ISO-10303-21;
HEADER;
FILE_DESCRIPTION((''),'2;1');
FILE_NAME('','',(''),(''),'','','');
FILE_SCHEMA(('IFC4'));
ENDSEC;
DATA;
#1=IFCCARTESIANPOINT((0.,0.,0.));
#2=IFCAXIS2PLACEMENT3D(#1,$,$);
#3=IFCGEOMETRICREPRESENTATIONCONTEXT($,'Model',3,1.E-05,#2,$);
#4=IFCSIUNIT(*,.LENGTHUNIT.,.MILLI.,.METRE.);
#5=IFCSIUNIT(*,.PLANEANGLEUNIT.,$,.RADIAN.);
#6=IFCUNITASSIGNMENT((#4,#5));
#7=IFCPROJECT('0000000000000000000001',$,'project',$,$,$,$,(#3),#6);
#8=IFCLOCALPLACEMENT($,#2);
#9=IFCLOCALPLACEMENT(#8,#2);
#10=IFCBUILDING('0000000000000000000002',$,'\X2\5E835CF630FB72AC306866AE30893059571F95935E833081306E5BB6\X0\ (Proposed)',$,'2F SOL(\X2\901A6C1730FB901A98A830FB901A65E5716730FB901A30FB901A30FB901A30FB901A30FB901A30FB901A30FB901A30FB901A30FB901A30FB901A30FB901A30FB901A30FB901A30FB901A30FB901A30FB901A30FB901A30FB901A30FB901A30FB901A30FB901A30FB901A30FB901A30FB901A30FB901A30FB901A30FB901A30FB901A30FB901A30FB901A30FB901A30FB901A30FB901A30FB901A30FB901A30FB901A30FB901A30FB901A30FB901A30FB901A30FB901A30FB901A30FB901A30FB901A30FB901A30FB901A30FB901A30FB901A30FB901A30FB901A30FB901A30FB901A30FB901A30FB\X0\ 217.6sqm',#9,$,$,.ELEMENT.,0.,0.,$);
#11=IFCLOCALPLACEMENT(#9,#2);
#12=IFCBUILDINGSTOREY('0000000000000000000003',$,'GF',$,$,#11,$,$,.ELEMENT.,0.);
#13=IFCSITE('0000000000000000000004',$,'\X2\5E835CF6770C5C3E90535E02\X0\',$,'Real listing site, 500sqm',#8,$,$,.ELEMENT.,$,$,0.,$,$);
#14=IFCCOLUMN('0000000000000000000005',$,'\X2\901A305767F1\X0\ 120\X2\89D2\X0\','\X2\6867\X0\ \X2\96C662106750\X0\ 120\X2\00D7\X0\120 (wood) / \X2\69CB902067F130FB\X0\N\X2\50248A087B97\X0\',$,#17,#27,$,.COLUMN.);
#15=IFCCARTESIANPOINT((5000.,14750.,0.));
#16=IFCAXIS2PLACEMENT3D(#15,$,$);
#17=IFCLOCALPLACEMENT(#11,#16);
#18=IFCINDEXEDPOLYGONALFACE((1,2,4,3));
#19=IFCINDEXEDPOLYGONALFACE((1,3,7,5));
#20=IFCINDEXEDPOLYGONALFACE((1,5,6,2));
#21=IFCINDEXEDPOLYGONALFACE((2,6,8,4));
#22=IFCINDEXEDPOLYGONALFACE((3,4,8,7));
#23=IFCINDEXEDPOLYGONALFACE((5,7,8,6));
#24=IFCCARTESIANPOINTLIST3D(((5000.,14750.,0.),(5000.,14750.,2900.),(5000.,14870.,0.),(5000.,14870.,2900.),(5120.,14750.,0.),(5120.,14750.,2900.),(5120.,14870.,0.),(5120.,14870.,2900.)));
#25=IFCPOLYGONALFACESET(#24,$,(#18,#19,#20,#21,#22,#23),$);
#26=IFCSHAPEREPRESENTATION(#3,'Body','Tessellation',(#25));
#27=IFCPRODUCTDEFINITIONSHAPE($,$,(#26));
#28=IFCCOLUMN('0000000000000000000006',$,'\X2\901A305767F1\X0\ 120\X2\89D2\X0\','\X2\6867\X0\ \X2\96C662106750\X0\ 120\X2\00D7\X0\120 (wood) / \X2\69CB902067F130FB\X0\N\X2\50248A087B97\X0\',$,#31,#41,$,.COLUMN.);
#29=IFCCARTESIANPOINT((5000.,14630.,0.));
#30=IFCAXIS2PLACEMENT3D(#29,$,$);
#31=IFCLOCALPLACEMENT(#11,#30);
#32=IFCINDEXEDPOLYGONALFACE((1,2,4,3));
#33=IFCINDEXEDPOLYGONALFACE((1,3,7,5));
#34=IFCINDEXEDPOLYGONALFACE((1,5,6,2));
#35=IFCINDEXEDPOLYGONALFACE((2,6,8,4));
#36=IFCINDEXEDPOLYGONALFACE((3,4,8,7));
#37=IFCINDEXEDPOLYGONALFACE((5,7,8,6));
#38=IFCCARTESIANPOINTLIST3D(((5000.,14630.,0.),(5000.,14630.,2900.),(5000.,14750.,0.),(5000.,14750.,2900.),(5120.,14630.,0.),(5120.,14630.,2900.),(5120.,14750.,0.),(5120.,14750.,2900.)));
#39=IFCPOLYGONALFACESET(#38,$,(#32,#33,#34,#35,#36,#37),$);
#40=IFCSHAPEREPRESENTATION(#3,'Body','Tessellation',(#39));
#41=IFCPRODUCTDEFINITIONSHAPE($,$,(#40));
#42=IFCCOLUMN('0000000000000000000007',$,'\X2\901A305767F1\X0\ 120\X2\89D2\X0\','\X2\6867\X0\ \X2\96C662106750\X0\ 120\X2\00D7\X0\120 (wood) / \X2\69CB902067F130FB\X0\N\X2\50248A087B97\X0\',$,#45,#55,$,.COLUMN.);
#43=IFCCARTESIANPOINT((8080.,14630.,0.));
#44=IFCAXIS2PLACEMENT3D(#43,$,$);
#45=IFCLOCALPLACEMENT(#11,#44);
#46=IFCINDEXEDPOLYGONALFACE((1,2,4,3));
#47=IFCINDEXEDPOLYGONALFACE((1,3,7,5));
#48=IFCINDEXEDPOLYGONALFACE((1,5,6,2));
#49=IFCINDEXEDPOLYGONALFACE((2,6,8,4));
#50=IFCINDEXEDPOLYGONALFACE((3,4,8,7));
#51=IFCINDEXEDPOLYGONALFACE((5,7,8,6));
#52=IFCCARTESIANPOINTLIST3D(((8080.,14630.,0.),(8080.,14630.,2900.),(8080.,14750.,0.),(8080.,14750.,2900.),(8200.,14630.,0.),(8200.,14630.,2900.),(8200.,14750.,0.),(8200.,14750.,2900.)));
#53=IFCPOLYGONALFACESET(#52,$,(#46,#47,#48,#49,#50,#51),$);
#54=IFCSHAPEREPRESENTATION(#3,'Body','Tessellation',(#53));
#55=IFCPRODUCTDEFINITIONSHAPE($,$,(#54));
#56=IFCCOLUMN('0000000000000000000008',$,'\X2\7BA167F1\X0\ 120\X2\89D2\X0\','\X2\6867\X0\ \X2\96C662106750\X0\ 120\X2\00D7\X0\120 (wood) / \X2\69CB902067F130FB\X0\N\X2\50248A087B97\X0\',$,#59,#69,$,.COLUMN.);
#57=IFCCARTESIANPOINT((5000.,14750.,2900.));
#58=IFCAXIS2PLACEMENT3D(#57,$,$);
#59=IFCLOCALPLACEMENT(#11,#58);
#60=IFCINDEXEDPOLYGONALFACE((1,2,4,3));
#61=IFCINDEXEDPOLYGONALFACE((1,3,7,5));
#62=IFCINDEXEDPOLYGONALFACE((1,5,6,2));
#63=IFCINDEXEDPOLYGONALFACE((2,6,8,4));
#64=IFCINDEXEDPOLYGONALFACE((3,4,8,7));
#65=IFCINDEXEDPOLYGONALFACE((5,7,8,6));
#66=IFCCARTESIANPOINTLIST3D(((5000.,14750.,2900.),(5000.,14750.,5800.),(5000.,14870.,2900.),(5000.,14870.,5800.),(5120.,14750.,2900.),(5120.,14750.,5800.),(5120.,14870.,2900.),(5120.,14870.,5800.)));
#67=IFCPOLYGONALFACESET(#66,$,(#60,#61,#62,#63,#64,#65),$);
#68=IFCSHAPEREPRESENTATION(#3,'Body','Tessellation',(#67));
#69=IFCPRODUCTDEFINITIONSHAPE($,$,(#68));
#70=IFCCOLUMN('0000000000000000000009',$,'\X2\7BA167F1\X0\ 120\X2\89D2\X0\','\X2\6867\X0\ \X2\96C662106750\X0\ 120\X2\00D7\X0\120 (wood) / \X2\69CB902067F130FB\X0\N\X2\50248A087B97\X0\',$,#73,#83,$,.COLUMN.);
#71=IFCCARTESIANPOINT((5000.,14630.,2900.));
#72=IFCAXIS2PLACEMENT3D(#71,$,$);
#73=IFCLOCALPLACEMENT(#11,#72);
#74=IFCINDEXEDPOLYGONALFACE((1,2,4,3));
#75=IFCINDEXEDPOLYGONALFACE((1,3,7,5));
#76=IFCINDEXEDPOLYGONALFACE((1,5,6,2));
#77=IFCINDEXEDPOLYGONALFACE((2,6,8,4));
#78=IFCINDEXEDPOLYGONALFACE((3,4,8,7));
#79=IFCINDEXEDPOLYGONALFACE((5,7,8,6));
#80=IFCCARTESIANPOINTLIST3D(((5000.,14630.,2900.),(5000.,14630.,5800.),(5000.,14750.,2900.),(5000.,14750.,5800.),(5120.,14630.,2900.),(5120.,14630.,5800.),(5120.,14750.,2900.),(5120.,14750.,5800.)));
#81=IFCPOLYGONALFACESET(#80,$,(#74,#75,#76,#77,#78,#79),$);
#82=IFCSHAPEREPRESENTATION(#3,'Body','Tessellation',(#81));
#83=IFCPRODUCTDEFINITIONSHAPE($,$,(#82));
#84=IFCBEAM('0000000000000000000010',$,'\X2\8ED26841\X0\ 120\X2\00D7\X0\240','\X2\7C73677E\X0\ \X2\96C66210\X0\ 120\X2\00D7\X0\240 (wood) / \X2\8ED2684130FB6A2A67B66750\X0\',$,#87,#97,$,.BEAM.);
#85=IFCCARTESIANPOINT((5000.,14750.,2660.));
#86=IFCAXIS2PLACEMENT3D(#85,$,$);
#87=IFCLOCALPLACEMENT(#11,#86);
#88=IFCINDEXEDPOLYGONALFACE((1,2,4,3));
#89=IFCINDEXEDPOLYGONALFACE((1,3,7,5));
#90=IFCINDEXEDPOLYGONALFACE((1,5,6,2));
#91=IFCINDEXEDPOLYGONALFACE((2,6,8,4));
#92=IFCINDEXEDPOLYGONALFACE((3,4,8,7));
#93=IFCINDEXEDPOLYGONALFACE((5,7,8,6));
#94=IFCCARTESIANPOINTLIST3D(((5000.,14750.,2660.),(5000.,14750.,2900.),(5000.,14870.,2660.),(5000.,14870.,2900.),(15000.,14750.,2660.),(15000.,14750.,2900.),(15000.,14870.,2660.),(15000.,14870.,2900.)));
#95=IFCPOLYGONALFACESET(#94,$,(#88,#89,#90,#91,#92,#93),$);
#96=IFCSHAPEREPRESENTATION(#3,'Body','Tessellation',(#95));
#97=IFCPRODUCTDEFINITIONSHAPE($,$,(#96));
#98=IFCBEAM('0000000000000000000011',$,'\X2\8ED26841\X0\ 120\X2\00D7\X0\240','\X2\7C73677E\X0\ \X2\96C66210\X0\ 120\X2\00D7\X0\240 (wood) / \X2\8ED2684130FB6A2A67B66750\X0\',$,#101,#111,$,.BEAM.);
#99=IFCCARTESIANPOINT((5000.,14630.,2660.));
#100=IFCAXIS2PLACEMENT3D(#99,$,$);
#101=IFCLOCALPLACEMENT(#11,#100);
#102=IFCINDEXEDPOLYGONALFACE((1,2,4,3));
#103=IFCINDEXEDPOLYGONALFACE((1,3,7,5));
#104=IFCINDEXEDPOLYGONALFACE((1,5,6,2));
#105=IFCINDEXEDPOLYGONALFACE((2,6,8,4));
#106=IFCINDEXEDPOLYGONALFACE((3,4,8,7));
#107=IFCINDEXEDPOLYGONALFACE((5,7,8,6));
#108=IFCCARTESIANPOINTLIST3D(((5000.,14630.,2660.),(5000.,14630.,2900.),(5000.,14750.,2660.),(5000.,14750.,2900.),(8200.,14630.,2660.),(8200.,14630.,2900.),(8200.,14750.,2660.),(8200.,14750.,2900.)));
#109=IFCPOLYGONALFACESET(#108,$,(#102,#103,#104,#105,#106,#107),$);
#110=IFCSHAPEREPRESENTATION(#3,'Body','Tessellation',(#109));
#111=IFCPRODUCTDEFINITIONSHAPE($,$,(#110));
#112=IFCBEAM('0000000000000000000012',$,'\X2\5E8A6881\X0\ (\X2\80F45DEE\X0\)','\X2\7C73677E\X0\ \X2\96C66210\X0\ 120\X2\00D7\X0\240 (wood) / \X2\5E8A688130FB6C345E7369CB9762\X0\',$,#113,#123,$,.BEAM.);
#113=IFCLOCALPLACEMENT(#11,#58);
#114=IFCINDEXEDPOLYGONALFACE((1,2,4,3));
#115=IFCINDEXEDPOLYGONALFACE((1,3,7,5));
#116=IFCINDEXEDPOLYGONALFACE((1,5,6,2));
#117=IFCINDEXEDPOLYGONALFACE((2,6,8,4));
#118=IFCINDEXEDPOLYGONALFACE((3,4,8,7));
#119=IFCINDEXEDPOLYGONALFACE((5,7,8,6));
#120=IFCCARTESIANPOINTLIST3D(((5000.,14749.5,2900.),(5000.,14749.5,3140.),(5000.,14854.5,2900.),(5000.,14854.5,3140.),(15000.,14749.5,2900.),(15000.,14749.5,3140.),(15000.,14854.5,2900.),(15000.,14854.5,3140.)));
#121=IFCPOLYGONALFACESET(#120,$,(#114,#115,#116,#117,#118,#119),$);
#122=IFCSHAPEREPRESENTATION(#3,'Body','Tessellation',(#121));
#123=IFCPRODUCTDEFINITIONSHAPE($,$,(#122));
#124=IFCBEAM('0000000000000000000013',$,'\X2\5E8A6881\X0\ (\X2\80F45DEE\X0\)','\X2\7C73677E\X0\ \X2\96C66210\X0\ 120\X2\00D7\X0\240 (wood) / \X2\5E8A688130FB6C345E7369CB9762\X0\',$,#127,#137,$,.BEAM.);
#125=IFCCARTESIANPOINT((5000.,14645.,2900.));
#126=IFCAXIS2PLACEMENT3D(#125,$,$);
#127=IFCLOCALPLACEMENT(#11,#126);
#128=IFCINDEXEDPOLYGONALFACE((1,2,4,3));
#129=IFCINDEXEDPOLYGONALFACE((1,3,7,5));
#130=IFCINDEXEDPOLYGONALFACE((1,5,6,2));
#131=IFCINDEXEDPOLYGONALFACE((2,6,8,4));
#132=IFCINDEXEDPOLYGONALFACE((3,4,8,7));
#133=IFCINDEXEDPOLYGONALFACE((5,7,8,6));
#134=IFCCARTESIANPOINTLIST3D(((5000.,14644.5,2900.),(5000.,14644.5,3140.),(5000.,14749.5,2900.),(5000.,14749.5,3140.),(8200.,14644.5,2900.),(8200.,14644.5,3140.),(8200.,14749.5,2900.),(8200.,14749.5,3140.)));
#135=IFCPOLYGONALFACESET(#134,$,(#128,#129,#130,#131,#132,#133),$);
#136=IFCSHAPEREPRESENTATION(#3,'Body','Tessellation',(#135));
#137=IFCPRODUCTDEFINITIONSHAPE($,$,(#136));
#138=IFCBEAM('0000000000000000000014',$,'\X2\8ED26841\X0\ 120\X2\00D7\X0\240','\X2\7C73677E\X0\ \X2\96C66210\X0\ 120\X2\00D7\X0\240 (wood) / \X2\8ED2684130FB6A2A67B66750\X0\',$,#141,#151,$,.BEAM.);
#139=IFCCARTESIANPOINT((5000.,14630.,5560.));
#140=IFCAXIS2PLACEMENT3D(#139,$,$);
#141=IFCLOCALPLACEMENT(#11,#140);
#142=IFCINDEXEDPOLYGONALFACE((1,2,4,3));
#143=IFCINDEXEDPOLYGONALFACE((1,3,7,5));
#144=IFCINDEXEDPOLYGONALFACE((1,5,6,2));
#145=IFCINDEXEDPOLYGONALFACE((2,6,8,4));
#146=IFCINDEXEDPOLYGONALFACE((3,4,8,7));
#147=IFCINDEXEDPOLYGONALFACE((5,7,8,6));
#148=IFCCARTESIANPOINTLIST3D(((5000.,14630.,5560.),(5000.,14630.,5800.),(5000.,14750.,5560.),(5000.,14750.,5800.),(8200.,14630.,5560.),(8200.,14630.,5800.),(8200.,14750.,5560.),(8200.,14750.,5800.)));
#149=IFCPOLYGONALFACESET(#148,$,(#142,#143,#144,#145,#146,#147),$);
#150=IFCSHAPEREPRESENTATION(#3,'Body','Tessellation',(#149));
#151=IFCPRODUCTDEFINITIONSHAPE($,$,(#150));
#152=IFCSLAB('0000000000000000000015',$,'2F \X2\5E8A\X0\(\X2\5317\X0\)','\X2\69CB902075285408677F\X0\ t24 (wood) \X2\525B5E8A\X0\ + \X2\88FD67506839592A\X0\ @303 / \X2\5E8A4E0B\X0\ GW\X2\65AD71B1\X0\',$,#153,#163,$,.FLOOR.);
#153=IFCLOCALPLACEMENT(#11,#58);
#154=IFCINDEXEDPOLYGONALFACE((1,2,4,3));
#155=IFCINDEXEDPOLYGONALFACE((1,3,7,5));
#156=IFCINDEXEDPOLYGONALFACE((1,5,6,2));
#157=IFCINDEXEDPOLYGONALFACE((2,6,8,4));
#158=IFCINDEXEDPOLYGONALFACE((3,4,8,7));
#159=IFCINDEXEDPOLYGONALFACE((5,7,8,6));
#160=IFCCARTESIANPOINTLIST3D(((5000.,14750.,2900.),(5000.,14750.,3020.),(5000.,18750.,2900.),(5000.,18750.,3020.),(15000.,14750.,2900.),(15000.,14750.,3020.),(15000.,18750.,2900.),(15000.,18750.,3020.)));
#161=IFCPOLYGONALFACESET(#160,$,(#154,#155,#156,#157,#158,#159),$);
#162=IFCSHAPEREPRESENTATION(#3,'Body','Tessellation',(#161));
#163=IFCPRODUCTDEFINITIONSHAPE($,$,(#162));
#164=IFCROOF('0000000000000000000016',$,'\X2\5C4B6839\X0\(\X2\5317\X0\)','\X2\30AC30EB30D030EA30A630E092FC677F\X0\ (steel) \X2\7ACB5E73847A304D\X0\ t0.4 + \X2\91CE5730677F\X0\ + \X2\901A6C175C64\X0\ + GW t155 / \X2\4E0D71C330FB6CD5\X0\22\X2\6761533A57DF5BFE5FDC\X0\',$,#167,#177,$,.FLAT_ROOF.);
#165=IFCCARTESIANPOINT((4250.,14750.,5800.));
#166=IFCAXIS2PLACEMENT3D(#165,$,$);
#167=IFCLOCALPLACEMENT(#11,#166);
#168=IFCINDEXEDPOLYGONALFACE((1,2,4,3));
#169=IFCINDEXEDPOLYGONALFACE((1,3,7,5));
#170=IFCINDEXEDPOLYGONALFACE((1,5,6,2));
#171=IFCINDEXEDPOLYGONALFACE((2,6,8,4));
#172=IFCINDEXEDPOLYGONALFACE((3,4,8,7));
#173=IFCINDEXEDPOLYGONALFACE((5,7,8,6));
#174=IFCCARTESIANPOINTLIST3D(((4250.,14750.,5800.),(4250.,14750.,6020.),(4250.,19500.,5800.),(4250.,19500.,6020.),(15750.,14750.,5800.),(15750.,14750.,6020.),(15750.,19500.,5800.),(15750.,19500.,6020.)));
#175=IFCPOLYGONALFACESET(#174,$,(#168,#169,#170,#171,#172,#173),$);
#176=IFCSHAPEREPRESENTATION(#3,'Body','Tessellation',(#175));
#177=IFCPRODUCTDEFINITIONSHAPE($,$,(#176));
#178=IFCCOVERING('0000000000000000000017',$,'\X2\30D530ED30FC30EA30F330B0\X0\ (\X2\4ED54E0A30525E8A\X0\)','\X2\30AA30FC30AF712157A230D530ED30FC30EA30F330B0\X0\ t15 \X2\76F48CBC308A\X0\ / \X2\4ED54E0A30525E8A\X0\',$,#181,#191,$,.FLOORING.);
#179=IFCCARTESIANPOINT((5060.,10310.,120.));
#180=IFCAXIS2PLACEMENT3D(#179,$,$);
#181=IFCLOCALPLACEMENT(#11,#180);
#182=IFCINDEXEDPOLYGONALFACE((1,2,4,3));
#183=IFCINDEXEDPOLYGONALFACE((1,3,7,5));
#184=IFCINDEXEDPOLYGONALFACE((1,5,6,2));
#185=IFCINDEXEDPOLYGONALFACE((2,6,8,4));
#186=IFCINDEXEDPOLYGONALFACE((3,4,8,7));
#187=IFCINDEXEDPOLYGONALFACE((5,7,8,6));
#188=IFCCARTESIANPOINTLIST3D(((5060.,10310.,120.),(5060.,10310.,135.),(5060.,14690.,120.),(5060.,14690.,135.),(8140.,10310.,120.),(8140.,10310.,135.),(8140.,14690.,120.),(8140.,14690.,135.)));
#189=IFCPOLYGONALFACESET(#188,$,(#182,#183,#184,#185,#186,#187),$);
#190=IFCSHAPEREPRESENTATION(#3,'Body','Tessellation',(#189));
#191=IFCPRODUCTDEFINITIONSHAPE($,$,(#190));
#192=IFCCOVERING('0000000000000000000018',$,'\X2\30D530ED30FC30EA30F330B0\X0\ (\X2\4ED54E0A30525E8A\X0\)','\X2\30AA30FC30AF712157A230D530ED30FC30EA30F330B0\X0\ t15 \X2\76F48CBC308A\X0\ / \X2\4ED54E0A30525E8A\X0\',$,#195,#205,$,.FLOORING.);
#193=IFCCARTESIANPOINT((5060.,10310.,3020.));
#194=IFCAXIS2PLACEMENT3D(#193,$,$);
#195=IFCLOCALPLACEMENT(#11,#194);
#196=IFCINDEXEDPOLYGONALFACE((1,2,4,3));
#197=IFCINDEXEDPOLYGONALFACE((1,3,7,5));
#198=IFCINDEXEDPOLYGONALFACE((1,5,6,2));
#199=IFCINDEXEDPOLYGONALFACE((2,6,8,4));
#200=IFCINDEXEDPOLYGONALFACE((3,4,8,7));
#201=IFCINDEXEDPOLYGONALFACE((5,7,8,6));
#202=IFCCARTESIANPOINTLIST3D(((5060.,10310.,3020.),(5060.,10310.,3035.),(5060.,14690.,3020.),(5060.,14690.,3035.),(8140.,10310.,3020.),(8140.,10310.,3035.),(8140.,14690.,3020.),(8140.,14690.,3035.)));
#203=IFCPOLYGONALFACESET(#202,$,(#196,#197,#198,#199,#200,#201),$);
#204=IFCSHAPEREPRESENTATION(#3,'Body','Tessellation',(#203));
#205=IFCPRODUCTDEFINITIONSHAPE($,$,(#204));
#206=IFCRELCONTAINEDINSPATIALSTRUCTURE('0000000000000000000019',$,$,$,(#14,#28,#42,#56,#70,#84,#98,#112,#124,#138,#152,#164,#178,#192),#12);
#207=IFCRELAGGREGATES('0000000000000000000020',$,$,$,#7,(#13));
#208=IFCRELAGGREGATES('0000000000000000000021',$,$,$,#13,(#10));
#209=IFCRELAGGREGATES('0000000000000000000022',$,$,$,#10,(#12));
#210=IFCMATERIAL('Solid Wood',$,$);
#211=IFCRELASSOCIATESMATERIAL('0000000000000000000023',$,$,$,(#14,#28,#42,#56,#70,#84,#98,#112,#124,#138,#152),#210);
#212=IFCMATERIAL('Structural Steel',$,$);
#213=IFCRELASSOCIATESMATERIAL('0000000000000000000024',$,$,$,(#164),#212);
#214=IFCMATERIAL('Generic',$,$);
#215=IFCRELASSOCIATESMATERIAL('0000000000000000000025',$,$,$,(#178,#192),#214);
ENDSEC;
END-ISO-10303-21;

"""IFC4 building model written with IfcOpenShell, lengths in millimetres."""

from ifc_helpers import new_model, si_unit, frame, frame_2d, origin, place, context, project, spatial, rectangle, extrude, material, element, save


model = new_model("IFC4")

# Units and contexts
model_context = context("Model", 3, precision=1e-05, world=origin())
ifc_project = project(units=[si_unit("LENGTHUNIT", "METRE", prefix="MILLI"), si_unit("PLANEANGLEUNIT", "RADIAN")], contexts=[model_context])

# Site, building, storey
site_placement = place(None, origin())
site = spatial("IfcSite", under=ifc_project, at=site_placement, Name="広島県尾道市", ObjectType="Real listing site, 500sqm", CompositionType="ELEMENT", RefElevation=0.0)
building_placement = place(site_placement, origin())
building = spatial("IfcBuilding", under=site, at=building_placement, Name="広島・犬と暮らす土間広めの家 (Proposed)", ObjectType="2F SOL(通気・通風・通日照・通・通・通・通・通・通・通・通・通・通・通・通・通・通・通・通・通・通・通・通・通・通・通・通・通・通・通・通・通・通・通・通・通・通・通・通・通・通・通・通・通・通・通・通・通・通・通・通・通・通・通・通・通・ 217.6sqm", CompositionType="ELEMENT", ElevationOfRefHeight=0.0, ElevationOfTerrain=0.0)
storey_placement = place(building_placement, origin())
storey = spatial("IfcBuildingStorey", under=building, at=storey_placement, Name="GF", CompositionType="ELEMENT", Elevation=0.0)

# Columns
ifc_material_1 = material(Name="Solid Wood")
column_1_placement = place(storey_placement, frame((5000.0, 14750.0, 0.0)))
element("IfcColumn", 1, at=column_1_placement, inside=storey, material=ifc_material_1, Name="通し柱 120角", Description="桧 集成材 120×120 (wood) / 構造柱・N値計算", PredefinedType="COLUMN", context=model_context, shape_type="SweptSolid", body=[
    extrude(rectangle(XDim=120.0, YDim=120.0, at=frame_2d((60.0, 60.0))), frame((5000.0, 14750.0, 0.0)), (0.0, 0.0, 1.0), 2900.0),
])
column_2_placement = place(storey_placement, frame((5000.0, 14630.0, 0.0)))
element("IfcColumn", 2, at=column_2_placement, inside=storey, material=ifc_material_1, Name="通し柱 120角", Description="桧 集成材 120×120 (wood) / 構造柱・N値計算", PredefinedType="COLUMN", context=model_context, shape_type="SweptSolid", body=[
    extrude(rectangle(XDim=120.0, YDim=120.0, at=frame_2d((60.0, 60.0))), frame((5000.0, 14630.0, 0.0)), (0.0, 0.0, 1.0), 2900.0),
])
column_3_placement = place(storey_placement, frame((8080.0, 14630.0, 0.0)))
element("IfcColumn", 3, at=column_3_placement, inside=storey, material=ifc_material_1, Name="通し柱 120角", Description="桧 集成材 120×120 (wood) / 構造柱・N値計算", PredefinedType="COLUMN", context=model_context, shape_type="SweptSolid", body=[
    extrude(rectangle(XDim=120.0, YDim=120.0, at=frame_2d((60.0, 60.0))), frame((8080.0, 14630.0, 0.0)), (0.0, 0.0, 1.0), 2900.0),
])
column_4_placement = place(storey_placement, frame((5000.0, 14750.0, 2900.0)))
element("IfcColumn", 4, at=column_4_placement, inside=storey, material=ifc_material_1, Name="管柱 120角", Description="桧 集成材 120×120 (wood) / 構造柱・N値計算", PredefinedType="COLUMN", context=model_context, shape_type="SweptSolid", body=[
    extrude(rectangle(XDim=120.0, YDim=120.0, at=frame_2d((60.0, 60.0))), frame((5000.0, 14750.0, 2900.0)), (0.0, 0.0, 1.0), 2900.0),
])
column_5_placement = place(storey_placement, frame((5000.0, 14630.0, 2900.0)))
element("IfcColumn", 5, at=column_5_placement, inside=storey, material=ifc_material_1, Name="管柱 120角", Description="桧 集成材 120×120 (wood) / 構造柱・N値計算", PredefinedType="COLUMN", context=model_context, shape_type="SweptSolid", body=[
    extrude(rectangle(XDim=120.0, YDim=120.0, at=frame_2d((60.0, 60.0))), frame((5000.0, 14630.0, 2900.0)), (0.0, 0.0, 1.0), 2900.0),
])

# Beams
beam_1_placement = place(storey_placement, frame((5000.0, 14750.0, 2660.0)))
element("IfcBeam", 6, at=beam_1_placement, inside=storey, material=ifc_material_1, Name="軒桁 120×240", Description="米松 集成 120×240 (wood) / 軒桁・横架材", PredefinedType="BEAM", context=model_context, shape_type="SweptSolid", body=[
    extrude(rectangle(XDim=10000.0, YDim=120.0, at=frame_2d((5000.0, 60.0))), frame((5000.0, 14750.0, 2660.0)), (0.0, 0.0, 1.0), 240.0),
])
beam_2_placement = place(storey_placement, frame((5000.0, 14630.0, 2660.0)))
element("IfcBeam", 7, at=beam_2_placement, inside=storey, material=ifc_material_1, Name="軒桁 120×240", Description="米松 集成 120×240 (wood) / 軒桁・横架材", PredefinedType="BEAM", context=model_context, shape_type="SweptSolid", body=[
    extrude(rectangle(XDim=3200.0, YDim=120.0, at=frame_2d((1600.0, 60.0))), frame((5000.0, 14630.0, 2660.0)), (0.0, 0.0, 1.0), 240.0),
])
beam_3_placement = place(storey_placement, frame((5000.0, 14750.0, 2900.0)))
element("IfcBeam", 8, at=beam_3_placement, inside=storey, material=ifc_material_1, Name="床梁 (胴差)", Description="米松 集成 120×240 (wood) / 床梁・水平構面", PredefinedType="BEAM", context=model_context, shape_type="SweptSolid", body=[
    extrude(rectangle(XDim=10000.0, YDim=105.0, at=frame_2d((5000.0, 52.0))), frame((5000.0, 14750.0, 2900.0)), (0.0, 0.0, 1.0), 240.0),
])
beam_4_placement = place(storey_placement, frame((5000.0, 14645.0, 2900.0)))
element("IfcBeam", 9, at=beam_4_placement, inside=storey, material=ifc_material_1, Name="床梁 (胴差)", Description="米松 集成 120×240 (wood) / 床梁・水平構面", PredefinedType="BEAM", context=model_context, shape_type="SweptSolid", body=[
    extrude(rectangle(XDim=3200.0, YDim=105.0, at=frame_2d((1600.0, 52.0))), frame((5000.0, 14645.0, 2900.0)), (0.0, 0.0, 1.0), 240.0),
])
beam_5_placement = place(storey_placement, frame((5000.0, 14630.0, 5560.0)))
element("IfcBeam", 10, at=beam_5_placement, inside=storey, material=ifc_material_1, Name="軒桁 120×240", Description="米松 集成 120×240 (wood) / 軒桁・横架材", PredefinedType="BEAM", context=model_context, shape_type="SweptSolid", body=[
    extrude(rectangle(XDim=3200.0, YDim=120.0, at=frame_2d((1600.0, 60.0))), frame((5000.0, 14630.0, 5560.0)), (0.0, 0.0, 1.0), 240.0),
])

# Slab
slab_1_placement = place(storey_placement, frame((5000.0, 14750.0, 2900.0)))
element("IfcSlab", 11, at=slab_1_placement, inside=storey, material=ifc_material_1, Name="2F 床(北)", Description="構造用合板 t24 (wood) 剛床 + 製材根太 @303 / 床下 GW断熱", PredefinedType="FLOOR", context=model_context, shape_type="SweptSolid", body=[
    extrude(rectangle(XDim=10000.0, YDim=4000.0, at=frame_2d((5000.0, 2000.0))), frame((5000.0, 14750.0, 2900.0)), (0.0, 0.0, 1.0), 120.0),
])

# Roof
ifc_material_2 = material(Name="Structural Steel")
for number, where, name in (
    (12, (4250.0, 14750.0, 5800.0), "屋根(北)"),
):
    element("IfcRoof", number, at=place(storey_placement, frame(where)), inside=storey, material=ifc_material_2, Name=name, Description="ガルバリウム鋼板 (steel) 立平葺き t0.4 + 野地板 + 通気層 + GW t155 / 不燃・法22条区域対応", PredefinedType="FLAT_ROOF", context=model_context, shape_type="SweptSolid", body=[
        extrude(rectangle(XDim=11500.0, YDim=4750.0, at=frame_2d((5750.0, 2375.0))), frame((4250.0, 14750.0, 5800.0)), (0.0, 0.0, 1.0), 220.0),
    ])

# Coverings
ifc_material_3 = material(Name="Generic")
covering_1_placement = place(storey_placement, frame((5060.0, 10310.0, 120.0)))
element("IfcCovering", 13, at=covering_1_placement, inside=storey, material=ifc_material_3, Name="フローリング (仕上げ床)", Description="オーク無垢フローリング t15 直貼り / 仕上げ床", PredefinedType="FLOORING", context=model_context, shape_type="SweptSolid", body=[
    extrude(rectangle(XDim=3080.0, YDim=4380.0, at=frame_2d((1540.0, 2190.0))), frame((5060.0, 10310.0, 120.0)), (0.0, 0.0, 1.0), 15.0),
])
covering_2_placement = place(storey_placement, frame((5060.0, 10310.0, 3020.0)))
element("IfcCovering", 14, at=covering_2_placement, inside=storey, material=ifc_material_3, Name="フローリング (仕上げ床)", Description="オーク無垢フローリング t15 直貼り / 仕上げ床", PredefinedType="FLOORING", context=model_context, shape_type="SweptSolid", body=[
    extrude(rectangle(XDim=3080.0, YDim=4380.0, at=frame_2d((1540.0, 2190.0))), frame((5060.0, 10310.0, 3020.0)), (0.0, 0.0, 1.0), 15.0),
])

save(model, "model.ifc")
